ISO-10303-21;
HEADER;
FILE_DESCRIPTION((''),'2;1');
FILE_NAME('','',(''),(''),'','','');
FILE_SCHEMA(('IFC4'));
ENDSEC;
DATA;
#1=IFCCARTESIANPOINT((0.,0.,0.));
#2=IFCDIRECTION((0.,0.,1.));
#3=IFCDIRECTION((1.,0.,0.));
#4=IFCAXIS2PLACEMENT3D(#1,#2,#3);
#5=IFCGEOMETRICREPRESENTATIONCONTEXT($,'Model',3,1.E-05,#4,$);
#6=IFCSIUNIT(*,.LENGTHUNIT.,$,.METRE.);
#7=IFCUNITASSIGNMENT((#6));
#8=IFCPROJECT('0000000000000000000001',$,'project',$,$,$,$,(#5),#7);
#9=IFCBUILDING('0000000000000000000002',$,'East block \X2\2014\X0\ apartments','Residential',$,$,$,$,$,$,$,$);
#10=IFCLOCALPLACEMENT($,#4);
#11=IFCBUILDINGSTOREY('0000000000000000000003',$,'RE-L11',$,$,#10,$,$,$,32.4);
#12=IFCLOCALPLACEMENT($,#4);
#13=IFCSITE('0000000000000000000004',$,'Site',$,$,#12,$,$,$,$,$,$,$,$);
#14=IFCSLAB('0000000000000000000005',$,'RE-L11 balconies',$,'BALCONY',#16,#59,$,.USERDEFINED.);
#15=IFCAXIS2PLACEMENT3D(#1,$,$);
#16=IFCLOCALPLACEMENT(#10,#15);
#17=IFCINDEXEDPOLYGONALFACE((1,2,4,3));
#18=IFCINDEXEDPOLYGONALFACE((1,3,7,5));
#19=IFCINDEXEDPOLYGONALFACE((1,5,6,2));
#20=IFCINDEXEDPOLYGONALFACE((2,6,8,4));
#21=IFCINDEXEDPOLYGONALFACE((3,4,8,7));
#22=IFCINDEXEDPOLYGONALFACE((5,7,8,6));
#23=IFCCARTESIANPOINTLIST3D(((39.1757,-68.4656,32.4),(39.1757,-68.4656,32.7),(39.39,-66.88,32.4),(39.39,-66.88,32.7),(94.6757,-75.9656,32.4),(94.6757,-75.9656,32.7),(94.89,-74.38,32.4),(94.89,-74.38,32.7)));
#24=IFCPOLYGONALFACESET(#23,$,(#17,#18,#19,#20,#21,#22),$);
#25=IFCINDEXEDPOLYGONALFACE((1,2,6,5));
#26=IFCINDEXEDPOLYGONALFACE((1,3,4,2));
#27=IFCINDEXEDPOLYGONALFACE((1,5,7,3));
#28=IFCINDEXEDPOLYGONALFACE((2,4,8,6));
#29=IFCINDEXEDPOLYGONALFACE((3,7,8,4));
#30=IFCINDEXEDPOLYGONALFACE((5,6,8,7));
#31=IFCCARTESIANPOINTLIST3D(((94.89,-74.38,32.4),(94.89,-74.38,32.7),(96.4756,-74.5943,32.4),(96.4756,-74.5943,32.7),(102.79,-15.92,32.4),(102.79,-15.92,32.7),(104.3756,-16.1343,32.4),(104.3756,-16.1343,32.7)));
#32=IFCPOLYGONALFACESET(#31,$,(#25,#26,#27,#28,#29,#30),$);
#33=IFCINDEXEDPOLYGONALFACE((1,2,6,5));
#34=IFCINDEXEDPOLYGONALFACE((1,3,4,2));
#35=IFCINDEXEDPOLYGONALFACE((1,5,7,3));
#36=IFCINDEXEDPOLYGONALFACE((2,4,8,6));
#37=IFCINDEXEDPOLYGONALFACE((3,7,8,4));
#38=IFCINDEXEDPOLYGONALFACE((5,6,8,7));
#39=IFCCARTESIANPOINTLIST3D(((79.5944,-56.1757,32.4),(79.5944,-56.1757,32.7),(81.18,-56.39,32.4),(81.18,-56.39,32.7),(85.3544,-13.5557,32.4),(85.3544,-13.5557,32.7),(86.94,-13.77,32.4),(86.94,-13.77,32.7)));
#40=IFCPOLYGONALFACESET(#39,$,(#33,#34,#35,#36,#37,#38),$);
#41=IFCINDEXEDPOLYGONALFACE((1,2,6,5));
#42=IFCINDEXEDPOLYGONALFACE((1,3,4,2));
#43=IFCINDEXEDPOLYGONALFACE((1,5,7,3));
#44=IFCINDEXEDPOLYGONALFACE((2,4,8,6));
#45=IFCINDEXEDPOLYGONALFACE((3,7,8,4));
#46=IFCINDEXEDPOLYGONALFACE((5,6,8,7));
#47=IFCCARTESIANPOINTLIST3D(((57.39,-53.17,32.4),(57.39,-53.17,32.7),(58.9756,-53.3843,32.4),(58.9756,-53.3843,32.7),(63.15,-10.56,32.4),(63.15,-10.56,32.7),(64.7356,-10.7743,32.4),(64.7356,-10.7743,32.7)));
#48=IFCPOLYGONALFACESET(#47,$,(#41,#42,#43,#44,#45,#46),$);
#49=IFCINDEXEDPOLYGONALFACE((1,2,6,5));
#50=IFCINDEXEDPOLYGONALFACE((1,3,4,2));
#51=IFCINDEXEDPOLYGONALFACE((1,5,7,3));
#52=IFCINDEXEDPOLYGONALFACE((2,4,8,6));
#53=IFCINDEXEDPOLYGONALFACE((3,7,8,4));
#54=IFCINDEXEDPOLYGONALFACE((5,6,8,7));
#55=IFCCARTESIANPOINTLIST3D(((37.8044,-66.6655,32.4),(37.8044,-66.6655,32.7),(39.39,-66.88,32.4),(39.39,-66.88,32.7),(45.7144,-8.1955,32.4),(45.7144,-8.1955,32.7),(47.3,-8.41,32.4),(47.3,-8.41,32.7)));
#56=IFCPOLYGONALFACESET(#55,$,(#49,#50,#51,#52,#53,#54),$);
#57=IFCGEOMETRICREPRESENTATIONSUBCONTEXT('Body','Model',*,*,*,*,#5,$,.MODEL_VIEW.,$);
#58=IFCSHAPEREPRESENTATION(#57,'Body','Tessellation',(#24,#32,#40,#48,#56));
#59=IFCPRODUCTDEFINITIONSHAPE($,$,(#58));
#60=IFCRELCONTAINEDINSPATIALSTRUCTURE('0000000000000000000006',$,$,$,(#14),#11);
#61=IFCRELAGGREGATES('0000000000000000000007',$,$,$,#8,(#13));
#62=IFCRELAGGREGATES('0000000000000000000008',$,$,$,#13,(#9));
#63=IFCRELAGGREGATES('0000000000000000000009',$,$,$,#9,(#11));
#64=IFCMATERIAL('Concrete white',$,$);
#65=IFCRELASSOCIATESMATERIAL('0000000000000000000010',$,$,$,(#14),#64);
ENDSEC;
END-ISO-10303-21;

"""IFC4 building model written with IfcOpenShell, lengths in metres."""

from ifc_helpers import new_model, si_unit, frame, origin_with_axes, place, context, subcontext, project, spatial, polyline, outline, extrude, material, element, save


model = new_model("IFC4")

# Units and contexts
model_context = context("Model", 3, precision=1e-05, world=origin_with_axes())
body_context = subcontext(model_context, "Body", "Model", "MODEL_VIEW")
ifc_project = project(units=[si_unit("LENGTHUNIT", "METRE")], contexts=[model_context])

# Site, building, storey
site_placement = place(None, origin_with_axes())
site = spatial("IfcSite", under=ifc_project, at=site_placement, Name="Site")
building = spatial("IfcBuilding", under=site, Name="East block — apartments", Description="Residential")
storey_placement = place(None, origin_with_axes())
storey = spatial("IfcBuildingStorey", under=building, at=storey_placement, Name="RE-L11", Elevation=32.4)

# Slab
ifc_material_1 = material(Name="Concrete white")
slab_placement = place(storey_placement, origin_with_axes())
element("IfcSlab", 1, at=slab_placement, inside=storey, material=ifc_material_1, Name="RE-L11 balconies", ObjectType="BALCONY", PredefinedType="USERDEFINED", context=body_context, shape_type="SweptSolid", body=[
    extrude(outline(polyline([(39.39, -66.88), (94.89, -74.38), (94.6757, -75.9656), (39.1757, -68.4656), (39.39, -66.88)])), frame((0.0, 0.0, 32.4), z_axis=(0.0, 0.0, 1.0), x_axis=(1.0, 0.0, 0.0)), (0.0, 0.0, 1.0), 0.3),
    extrude(outline(polyline([(94.89, -74.38), (102.79, -15.92), (104.3756, -16.1343), (96.4756, -74.5943), (94.89, -74.38)])), frame((0.0, 0.0, 32.4), z_axis=(0.0, 0.0, 1.0), x_axis=(1.0, 0.0, 0.0)), (0.0, 0.0, 1.0), 0.3),
    extrude(outline(polyline([(86.94, -13.77), (81.18, -56.39), (79.5944, -56.1757), (85.3544, -13.5557), (86.94, -13.77)])), frame((0.0, 0.0, 32.4), z_axis=(0.0, 0.0, 1.0), x_axis=(1.0, 0.0, 0.0)), (0.0, 0.0, 1.0), 0.3),
    extrude(outline(polyline([(57.39, -53.17), (63.15, -10.56), (64.7356, -10.7743), (58.9756, -53.3843), (57.39, -53.17)])), frame((0.0, 0.0, 32.4), z_axis=(0.0, 0.0, 1.0), x_axis=(1.0, 0.0, 0.0)), (0.0, 0.0, 1.0), 0.3),
    extrude(outline(polyline([(47.3, -8.41), (39.39, -66.88), (37.8044, -66.6655), (45.7144, -8.1955), (47.3, -8.41)])), frame((0.0, 0.0, 32.4), z_axis=(0.0, 0.0, 1.0), x_axis=(1.0, 0.0, 0.0)), (0.0, 0.0, 1.0), 0.3),
])

save(model, "model.ifc")
